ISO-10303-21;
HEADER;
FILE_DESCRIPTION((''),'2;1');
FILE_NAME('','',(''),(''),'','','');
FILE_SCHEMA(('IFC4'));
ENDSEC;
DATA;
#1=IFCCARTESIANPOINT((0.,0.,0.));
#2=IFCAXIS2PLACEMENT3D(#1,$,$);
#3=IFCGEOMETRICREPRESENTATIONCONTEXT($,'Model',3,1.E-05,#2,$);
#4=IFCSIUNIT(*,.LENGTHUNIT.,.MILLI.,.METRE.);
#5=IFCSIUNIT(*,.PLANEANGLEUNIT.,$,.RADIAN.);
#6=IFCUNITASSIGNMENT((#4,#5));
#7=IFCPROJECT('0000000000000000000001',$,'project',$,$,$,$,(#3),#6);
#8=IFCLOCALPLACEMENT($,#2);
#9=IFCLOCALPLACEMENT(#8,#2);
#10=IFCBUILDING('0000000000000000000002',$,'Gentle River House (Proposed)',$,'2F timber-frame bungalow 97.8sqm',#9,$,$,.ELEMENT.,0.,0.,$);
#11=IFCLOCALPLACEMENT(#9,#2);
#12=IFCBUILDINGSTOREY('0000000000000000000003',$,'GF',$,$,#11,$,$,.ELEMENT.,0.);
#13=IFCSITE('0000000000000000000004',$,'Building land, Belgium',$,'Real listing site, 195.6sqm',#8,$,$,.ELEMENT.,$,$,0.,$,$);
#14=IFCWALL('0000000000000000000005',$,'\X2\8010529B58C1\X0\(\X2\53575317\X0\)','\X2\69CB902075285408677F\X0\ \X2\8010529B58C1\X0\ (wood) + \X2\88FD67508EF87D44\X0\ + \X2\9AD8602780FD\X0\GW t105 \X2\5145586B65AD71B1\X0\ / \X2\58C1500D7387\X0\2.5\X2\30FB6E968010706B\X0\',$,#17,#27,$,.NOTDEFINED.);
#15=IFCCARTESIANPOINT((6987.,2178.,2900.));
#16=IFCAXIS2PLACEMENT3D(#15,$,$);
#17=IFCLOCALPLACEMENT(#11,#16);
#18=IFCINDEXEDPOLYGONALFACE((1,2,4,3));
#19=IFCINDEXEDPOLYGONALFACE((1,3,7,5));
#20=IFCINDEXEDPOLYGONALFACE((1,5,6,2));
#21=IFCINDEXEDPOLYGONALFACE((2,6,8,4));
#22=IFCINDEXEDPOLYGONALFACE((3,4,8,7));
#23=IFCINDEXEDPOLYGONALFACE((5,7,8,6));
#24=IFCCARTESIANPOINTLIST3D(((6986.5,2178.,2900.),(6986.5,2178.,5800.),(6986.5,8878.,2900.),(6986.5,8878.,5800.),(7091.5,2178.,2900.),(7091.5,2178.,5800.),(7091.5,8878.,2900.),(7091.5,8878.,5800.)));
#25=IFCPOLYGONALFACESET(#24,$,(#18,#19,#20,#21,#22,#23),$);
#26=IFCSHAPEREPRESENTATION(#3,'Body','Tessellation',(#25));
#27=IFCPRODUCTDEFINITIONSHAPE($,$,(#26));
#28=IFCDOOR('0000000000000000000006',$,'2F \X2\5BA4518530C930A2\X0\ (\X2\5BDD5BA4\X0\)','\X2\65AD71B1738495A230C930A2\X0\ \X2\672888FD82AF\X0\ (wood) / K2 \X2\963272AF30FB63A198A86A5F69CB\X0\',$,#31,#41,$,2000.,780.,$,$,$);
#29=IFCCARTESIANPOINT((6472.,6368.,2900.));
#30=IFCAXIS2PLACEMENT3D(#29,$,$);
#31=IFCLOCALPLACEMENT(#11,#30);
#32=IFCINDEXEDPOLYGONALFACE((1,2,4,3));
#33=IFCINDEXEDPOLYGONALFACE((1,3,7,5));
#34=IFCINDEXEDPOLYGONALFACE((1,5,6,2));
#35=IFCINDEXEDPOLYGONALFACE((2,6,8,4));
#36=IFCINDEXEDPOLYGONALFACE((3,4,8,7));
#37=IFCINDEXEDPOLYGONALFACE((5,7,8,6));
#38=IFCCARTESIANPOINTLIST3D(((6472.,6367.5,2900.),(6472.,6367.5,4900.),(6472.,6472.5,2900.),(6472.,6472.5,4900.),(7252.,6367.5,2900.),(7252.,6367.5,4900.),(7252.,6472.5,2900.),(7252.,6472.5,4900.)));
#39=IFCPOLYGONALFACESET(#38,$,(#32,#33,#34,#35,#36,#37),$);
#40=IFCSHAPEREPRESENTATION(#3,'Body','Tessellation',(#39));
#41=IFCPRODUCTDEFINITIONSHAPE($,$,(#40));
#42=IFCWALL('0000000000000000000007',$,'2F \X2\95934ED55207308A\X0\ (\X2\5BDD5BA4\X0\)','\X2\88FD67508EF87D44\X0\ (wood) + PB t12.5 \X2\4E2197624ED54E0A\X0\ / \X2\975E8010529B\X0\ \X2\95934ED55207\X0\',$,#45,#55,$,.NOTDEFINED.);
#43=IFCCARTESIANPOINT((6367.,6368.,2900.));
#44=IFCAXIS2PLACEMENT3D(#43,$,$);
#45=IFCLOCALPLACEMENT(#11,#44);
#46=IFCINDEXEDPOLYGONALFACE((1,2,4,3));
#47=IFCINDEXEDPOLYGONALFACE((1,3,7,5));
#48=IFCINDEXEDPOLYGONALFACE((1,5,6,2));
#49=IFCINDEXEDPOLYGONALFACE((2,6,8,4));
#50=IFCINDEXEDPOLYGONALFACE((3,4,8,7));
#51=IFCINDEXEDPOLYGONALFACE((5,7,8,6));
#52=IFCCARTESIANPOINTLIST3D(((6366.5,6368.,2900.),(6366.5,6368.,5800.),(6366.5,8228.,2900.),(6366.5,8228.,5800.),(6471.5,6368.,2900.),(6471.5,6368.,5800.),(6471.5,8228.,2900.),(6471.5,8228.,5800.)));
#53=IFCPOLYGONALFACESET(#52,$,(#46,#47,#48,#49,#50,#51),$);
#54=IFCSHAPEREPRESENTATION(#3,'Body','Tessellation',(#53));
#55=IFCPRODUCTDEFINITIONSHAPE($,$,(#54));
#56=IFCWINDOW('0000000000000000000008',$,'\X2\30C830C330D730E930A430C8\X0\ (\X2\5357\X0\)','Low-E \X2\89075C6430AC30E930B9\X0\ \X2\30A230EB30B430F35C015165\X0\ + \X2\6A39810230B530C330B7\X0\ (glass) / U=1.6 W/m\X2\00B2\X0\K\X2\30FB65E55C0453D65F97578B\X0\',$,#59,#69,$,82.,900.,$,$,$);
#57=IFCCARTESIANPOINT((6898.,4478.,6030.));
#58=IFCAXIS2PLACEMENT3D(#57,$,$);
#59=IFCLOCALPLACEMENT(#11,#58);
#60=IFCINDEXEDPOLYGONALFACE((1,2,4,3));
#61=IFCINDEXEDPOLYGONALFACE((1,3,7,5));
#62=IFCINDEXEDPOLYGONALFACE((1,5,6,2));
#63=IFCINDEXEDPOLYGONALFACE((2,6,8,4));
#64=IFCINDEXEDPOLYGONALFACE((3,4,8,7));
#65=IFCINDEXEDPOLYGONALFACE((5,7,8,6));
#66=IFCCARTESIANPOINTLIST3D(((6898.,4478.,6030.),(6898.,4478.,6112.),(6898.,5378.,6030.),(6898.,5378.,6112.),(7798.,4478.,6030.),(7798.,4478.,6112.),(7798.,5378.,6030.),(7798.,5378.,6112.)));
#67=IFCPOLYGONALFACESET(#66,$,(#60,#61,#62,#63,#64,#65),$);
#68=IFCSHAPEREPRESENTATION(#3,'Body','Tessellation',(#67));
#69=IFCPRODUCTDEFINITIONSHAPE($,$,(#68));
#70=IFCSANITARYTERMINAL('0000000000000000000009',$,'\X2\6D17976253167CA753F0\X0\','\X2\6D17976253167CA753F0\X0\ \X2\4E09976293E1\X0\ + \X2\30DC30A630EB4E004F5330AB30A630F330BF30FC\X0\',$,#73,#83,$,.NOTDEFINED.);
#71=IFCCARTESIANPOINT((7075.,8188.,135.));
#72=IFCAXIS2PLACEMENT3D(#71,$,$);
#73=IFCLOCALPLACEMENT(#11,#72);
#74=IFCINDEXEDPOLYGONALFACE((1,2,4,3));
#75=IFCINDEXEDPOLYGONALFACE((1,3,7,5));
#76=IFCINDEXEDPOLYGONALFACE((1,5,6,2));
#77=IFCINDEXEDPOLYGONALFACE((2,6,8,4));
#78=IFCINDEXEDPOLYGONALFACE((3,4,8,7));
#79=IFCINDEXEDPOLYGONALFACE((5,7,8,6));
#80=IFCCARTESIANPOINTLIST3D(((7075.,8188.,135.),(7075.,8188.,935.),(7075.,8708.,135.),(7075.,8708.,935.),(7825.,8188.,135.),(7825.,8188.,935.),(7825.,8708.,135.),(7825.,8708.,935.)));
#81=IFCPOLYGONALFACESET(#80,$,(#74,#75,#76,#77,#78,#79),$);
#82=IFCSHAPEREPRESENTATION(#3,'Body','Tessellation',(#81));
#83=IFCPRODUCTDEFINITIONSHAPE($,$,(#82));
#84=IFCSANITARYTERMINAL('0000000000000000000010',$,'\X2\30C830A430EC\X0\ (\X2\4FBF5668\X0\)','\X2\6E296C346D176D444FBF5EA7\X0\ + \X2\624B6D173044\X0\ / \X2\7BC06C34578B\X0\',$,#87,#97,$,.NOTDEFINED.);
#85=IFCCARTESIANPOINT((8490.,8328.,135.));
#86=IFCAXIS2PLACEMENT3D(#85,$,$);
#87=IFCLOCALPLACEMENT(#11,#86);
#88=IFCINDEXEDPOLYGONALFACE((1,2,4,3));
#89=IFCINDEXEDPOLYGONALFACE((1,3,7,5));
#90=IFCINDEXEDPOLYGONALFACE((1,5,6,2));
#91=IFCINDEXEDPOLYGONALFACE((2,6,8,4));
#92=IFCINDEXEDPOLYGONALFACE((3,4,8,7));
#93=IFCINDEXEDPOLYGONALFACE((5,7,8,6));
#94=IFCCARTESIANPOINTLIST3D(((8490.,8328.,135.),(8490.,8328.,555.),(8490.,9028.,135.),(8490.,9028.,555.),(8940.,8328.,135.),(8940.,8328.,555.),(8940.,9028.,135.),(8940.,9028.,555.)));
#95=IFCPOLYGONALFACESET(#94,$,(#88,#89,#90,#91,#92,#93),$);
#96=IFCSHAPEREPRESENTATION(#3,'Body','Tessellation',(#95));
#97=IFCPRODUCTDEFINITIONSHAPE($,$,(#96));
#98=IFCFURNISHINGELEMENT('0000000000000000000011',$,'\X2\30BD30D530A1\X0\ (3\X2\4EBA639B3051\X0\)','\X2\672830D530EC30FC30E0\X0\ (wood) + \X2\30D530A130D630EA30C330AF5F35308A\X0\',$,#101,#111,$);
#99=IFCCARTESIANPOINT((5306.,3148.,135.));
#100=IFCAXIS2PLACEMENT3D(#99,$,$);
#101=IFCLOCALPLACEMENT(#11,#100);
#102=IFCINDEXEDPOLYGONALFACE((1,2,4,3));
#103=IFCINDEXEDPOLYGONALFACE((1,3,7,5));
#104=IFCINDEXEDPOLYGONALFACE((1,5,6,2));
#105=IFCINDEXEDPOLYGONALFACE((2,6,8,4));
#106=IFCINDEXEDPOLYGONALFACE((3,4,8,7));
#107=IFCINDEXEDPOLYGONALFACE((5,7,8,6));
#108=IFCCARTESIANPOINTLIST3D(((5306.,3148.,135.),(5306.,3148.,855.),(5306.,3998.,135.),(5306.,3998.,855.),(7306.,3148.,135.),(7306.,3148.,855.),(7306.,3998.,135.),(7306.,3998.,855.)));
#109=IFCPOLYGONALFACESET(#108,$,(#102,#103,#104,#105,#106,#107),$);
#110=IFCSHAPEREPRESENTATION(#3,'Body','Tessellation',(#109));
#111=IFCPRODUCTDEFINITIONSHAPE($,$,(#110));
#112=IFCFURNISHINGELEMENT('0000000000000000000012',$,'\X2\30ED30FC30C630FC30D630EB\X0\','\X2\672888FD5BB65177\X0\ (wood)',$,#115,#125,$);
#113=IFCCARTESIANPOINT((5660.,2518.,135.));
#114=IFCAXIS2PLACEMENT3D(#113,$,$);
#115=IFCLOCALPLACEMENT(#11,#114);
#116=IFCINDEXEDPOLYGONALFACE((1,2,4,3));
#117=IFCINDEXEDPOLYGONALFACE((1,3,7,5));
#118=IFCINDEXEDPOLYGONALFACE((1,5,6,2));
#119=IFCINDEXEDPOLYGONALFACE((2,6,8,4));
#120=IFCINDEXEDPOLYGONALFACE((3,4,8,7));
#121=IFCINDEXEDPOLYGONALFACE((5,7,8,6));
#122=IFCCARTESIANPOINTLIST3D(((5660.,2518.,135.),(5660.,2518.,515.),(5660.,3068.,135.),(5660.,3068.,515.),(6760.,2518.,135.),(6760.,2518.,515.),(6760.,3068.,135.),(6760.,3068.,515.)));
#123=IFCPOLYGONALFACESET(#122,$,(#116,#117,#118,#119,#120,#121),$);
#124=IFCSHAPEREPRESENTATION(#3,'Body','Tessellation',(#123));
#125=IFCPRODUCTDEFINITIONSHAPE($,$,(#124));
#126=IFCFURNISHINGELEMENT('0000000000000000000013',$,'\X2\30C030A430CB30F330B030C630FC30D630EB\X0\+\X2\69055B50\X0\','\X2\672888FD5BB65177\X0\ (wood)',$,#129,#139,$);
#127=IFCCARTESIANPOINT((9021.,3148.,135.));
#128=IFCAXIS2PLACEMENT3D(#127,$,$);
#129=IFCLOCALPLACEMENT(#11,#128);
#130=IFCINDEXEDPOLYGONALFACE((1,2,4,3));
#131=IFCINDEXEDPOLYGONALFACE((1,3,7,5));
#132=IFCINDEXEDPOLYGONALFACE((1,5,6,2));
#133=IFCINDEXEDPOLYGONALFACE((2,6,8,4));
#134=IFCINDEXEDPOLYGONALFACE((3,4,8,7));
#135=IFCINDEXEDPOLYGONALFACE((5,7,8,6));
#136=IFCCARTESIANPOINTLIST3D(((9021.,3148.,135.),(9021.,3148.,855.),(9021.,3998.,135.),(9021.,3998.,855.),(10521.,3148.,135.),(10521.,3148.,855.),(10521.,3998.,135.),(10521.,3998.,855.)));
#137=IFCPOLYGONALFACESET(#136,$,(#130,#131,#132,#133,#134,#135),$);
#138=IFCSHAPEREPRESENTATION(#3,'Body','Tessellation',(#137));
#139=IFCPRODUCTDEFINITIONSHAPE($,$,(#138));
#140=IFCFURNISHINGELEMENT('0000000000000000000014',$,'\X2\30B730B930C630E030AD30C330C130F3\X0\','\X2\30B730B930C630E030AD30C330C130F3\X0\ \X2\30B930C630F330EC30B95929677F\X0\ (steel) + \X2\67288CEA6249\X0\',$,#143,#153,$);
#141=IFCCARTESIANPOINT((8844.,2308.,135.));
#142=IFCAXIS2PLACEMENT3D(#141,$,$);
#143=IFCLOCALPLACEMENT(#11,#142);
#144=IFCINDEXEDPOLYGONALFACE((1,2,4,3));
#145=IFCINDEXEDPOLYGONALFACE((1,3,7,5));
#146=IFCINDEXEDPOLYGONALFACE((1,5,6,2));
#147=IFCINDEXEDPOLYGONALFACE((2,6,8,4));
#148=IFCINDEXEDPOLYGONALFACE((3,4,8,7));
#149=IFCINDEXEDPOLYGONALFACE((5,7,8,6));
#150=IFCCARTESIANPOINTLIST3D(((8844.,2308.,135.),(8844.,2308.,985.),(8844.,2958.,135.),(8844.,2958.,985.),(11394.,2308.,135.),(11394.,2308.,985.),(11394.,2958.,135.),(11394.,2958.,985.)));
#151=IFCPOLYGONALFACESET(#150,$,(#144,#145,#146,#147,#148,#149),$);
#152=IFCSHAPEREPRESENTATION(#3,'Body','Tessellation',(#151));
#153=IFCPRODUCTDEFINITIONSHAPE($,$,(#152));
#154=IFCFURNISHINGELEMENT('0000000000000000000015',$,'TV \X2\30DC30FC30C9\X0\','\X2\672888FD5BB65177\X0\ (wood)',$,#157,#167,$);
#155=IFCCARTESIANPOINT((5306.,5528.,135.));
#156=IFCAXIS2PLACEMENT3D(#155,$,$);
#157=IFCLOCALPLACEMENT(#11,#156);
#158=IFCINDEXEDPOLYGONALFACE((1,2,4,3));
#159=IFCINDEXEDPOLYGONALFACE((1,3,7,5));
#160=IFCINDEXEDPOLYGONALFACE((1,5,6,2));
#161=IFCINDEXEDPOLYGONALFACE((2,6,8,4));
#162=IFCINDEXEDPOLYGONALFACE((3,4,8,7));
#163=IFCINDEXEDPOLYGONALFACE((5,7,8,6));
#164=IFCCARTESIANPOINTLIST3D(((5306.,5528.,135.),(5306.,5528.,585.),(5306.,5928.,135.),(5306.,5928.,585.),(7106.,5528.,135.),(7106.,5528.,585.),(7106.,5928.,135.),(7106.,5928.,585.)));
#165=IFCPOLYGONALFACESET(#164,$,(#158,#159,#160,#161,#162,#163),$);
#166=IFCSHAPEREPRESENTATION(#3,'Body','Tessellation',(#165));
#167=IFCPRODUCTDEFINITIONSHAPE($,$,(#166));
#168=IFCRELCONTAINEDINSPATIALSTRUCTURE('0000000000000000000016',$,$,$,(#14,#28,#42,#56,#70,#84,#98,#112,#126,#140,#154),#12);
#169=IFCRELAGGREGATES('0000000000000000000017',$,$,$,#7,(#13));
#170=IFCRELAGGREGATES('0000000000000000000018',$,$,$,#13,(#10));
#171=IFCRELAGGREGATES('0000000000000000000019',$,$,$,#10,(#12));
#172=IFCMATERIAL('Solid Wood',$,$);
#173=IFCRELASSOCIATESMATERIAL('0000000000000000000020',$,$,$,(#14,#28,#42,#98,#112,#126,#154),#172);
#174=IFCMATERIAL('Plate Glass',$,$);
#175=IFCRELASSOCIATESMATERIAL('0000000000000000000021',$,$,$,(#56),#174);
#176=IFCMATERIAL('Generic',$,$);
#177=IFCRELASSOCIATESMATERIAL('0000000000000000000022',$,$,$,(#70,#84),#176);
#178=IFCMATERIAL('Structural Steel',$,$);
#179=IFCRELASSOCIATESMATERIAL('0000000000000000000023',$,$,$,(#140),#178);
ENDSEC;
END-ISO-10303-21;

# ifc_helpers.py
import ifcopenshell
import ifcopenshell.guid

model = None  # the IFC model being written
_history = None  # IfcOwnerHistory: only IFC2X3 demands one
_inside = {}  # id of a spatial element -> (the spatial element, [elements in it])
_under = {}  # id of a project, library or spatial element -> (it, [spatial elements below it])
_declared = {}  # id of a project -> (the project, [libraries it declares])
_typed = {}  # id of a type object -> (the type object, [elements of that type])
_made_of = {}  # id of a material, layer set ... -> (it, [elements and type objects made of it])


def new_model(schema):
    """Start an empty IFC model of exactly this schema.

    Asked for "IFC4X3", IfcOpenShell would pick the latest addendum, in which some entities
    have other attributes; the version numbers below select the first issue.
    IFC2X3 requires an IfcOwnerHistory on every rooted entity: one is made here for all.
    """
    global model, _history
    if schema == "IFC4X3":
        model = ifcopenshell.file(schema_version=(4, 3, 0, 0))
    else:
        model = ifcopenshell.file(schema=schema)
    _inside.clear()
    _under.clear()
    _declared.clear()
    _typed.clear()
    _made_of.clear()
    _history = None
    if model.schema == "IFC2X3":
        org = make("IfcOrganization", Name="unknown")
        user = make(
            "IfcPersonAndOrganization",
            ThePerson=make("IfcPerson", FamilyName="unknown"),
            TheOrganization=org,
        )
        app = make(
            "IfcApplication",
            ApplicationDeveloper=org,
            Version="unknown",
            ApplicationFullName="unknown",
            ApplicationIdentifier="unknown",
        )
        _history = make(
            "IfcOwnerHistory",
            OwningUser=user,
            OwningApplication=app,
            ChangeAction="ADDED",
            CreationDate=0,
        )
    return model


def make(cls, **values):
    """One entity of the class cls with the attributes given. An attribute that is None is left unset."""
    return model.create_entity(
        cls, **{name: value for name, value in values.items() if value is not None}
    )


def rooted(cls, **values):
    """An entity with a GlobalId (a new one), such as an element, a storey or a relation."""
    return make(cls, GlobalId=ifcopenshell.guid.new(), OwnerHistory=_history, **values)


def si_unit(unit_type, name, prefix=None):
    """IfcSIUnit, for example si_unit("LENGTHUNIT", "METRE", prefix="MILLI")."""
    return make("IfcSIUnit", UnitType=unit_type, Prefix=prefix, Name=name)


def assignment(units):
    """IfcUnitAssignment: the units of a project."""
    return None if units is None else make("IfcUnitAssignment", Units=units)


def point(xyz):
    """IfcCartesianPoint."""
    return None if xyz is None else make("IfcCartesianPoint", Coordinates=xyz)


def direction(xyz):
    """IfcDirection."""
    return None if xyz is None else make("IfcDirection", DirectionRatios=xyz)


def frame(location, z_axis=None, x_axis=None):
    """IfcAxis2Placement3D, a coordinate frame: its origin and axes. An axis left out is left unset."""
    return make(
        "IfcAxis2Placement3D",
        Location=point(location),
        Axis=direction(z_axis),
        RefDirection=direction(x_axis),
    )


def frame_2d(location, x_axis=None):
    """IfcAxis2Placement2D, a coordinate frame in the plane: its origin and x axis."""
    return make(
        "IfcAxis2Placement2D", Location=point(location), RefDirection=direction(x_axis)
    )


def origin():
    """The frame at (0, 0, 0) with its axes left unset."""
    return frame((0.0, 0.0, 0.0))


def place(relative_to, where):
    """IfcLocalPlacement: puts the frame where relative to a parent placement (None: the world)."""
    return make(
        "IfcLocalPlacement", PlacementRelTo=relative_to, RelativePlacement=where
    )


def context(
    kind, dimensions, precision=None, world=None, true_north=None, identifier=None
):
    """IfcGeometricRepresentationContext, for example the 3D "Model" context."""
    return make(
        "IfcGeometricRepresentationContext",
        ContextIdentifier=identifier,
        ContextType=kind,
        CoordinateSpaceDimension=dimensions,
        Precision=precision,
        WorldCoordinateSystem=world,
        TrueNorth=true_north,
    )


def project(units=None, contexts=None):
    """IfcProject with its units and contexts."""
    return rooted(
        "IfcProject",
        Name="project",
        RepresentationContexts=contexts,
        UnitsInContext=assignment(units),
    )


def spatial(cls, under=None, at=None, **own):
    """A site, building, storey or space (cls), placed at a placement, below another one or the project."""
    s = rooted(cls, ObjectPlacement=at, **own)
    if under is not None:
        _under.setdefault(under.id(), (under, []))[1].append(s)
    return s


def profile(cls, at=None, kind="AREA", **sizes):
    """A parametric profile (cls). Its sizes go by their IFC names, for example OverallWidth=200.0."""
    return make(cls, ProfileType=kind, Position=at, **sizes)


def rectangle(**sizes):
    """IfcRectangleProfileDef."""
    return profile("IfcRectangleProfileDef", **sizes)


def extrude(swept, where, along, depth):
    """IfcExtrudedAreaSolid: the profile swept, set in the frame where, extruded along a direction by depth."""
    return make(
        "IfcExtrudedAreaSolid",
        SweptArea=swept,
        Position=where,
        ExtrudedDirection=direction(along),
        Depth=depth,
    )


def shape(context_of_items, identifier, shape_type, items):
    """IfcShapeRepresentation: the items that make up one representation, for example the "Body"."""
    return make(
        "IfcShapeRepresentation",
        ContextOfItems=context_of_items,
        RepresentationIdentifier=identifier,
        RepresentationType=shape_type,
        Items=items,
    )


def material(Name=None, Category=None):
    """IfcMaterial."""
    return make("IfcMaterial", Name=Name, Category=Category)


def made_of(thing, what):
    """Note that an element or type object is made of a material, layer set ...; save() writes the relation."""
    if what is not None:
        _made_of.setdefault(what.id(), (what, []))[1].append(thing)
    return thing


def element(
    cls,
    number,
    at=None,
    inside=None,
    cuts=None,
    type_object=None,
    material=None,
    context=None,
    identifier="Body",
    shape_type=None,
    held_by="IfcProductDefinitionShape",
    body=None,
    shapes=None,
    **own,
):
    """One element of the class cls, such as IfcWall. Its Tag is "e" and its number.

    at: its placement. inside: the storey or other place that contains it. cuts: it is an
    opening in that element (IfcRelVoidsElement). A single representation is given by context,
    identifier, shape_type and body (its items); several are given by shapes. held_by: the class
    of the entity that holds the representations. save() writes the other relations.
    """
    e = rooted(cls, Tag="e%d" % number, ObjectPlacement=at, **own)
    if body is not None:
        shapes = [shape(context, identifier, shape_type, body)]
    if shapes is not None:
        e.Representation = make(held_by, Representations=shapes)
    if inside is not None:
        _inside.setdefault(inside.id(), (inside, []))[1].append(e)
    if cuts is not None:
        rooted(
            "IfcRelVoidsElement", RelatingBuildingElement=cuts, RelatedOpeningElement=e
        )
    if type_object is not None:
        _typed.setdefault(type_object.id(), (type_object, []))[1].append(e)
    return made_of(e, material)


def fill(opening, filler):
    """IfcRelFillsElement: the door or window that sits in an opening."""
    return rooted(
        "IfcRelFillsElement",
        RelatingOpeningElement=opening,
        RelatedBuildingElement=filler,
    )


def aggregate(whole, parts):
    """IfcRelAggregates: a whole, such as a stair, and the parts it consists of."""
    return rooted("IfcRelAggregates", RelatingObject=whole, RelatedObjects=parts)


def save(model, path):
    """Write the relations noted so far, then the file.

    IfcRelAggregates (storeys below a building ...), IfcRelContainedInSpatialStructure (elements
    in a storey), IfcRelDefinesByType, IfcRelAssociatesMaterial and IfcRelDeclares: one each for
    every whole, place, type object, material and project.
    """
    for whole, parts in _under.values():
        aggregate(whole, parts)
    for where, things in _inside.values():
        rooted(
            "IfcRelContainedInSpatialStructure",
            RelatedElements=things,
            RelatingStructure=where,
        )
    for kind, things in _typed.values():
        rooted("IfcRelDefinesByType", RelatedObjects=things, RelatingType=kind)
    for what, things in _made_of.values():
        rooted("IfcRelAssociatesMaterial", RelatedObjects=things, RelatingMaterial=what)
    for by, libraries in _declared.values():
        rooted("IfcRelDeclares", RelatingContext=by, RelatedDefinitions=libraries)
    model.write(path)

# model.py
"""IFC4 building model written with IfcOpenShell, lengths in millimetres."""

from ifc_helpers import new_model, si_unit, frame, frame_2d, origin, place, context, project, spatial, rectangle, extrude, material, element, fill, save


model = new_model("IFC4")

# Units and contexts
model_context = context("Model", 3, precision=1e-05, world=origin())
ifc_project = project(units=[si_unit("LENGTHUNIT", "METRE", prefix="MILLI"), si_unit("PLANEANGLEUNIT", "RADIAN")], contexts=[model_context])

# Site, building, storey
site_placement = place(None, origin())
site = spatial("IfcSite", under=ifc_project, at=site_placement, Name="Building land, Belgium", ObjectType="Real listing site, 195.6sqm", CompositionType="ELEMENT", RefElevation=0.0)
building_placement = place(site_placement, origin())
building = spatial("IfcBuilding", under=site, at=building_placement, Name="Gentle River House (Proposed)", ObjectType="2F timber-frame bungalow 97.8sqm", CompositionType="ELEMENT", ElevationOfRefHeight=0.0, ElevationOfTerrain=0.0)
storey_placement = place(building_placement, origin())
storey = spatial("IfcBuildingStorey", under=building, at=storey_placement, Name="GF", CompositionType="ELEMENT", Elevation=0.0)

# Shared definitions
ifc_material_1 = material(Name="Solid Wood")

# Wall, opening, door
wall_1_placement = place(storey_placement, frame((6987.0, 2178.0, 2900.0)))
wall_1 = element("IfcWall", 1, at=wall_1_placement, inside=storey, material=ifc_material_1, Name="耐力壁(南北)", Description="構造用合板 耐力壁 (wood) + 製材軸組 + 高性能GW t105 充填断熱 / 壁倍率2.5・準耐火", PredefinedType="NOTDEFINED", context=model_context, shape_type="SweptSolid", body=[
    extrude(rectangle(XDim=105.0, YDim=6700.0, at=frame_2d((52.0, 3350.0))), frame((6987.0, 2178.0, 2900.0)), (0.0, 0.0, 1.0), 2900.0),
])
opening_1_placement = place(storey_placement, frame((6472.0, 6368.0, 2900.0)))
opening_1 = element("IfcOpeningElement", 2, at=opening_1_placement, cuts=wall_1, PredefinedType="NOTDEFINED", context=model_context, shape_type="SweptSolid", body=[
    extrude(rectangle(XDim=780.0, YDim=105.0, at=frame_2d((390.0, 52.0))), frame((6472.0, 6368.0, 2900.0)), (0.0, 0.0, 1.0), 2000.0),
])
door_1_placement = place(storey_placement, frame((6472.0, 6368.0, 2900.0)))
door_1 = element("IfcDoor", 3, at=door_1_placement, inside=storey, material=ifc_material_1, Name="2F 室内ドア (寝室)", Description="断熱玄関ドア 木製芯 (wood) / K2 防犯・採風機構", OverallHeight=2000.0, OverallWidth=780.0, context=model_context, shape_type="SweptSolid", body=[
    extrude(rectangle(XDim=780.0, YDim=105.0, at=frame_2d((390.0, 52.0))), frame((6472.0, 6368.0, 2900.0)), (0.0, 0.0, 1.0), 2000.0),
])
fill(opening_1, door_1)

# Wall
wall_2_placement = place(storey_placement, frame((6367.0, 6368.0, 2900.0)))
element("IfcWall", 4, at=wall_2_placement, inside=storey, material=ifc_material_1, Name="2F 間仕切り (寝室)", Description="製材軸組 (wood) + PB t12.5 両面仕上 / 非耐力 間仕切", PredefinedType="NOTDEFINED", context=model_context, shape_type="SweptSolid", body=[
    extrude(rectangle(XDim=105.0, YDim=1860.0, at=frame_2d((52.0, 930.0))), frame((6367.0, 6368.0, 2900.0)), (0.0, 0.0, 1.0), 2900.0),
])

# Window
ifc_material_2 = material(Name="Plate Glass")
window_placement = place(storey_placement, frame((6898.0, 4478.0, 6030.0)))
element("IfcWindow", 5, at=window_placement, inside=storey, material=ifc_material_2, Name="トップライト (南)", Description="Low-E 複層ガラス アルゴン封入 + 樹脂サッシ (glass) / U=1.6 W/m²K・日射取得型", OverallHeight=82.0, OverallWidth=900.0, context=model_context, shape_type="SweptSolid", body=[
    extrude(rectangle(XDim=900.0, YDim=900.0, at=frame_2d((450.0, 450.0))), frame((6898.0, 4478.0, 6030.0)), (0.0, 0.0, 1.0), 82.0),
])

# Sanitary terminals
ifc_material_3 = material(Name="Generic")
sanitary_terminal_1_placement = place(storey_placement, frame((7075.0, 8188.0, 135.0)))
element("IfcSanitaryTerminal", 6, at=sanitary_terminal_1_placement, inside=storey, material=ifc_material_3, Name="洗面化粧台", Description="洗面化粧台 三面鏡 + ボウル一体カウンター", PredefinedType="NOTDEFINED", context=model_context, shape_type="SweptSolid", body=[
    extrude(rectangle(XDim=750.0, YDim=520.0, at=frame_2d((375.0, 260.0))), frame((7075.0, 8188.0, 135.0)), (0.0, 0.0, 1.0), 800.0),
])
sanitary_terminal_2_placement = place(storey_placement, frame((8490.0, 8328.0, 135.0)))
element("IfcSanitaryTerminal", 7, at=sanitary_terminal_2_placement, inside=storey, material=ifc_material_3, Name="トイレ (便器)", Description="温水洗浄便座 + 手洗い / 節水型", PredefinedType="NOTDEFINED", context=model_context, shape_type="SweptSolid", body=[
    extrude(rectangle(XDim=450.0, YDim=700.0, at=frame_2d((225.0, 350.0))), frame((8490.0, 8328.0, 135.0)), (0.0, 0.0, 1.0), 420.0),
])

# Furnishing elements
furnishing_1_placement = place(storey_placement, frame((5306.0, 3148.0, 135.0)))
element("IfcFurnishingElement", 8, at=furnishing_1_placement, inside=storey, material=ifc_material_1, Name="ソファ (3人掛け)", Description="木フレーム (wood) + ファブリック張り", context=model_context, shape_type="SweptSolid", body=[
    extrude(rectangle(XDim=2000.0, YDim=850.0, at=frame_2d((1000.0, 425.0))), frame((5306.0, 3148.0, 135.0)), (0.0, 0.0, 1.0), 720.0),
])
furnishing_2_placement = place(storey_placement, frame((5660.0, 2518.0, 135.0)))
element("IfcFurnishingElement", 9, at=furnishing_2_placement, inside=storey, material=ifc_material_1, Name="ローテーブル", Description="木製家具 (wood)", context=model_context, shape_type="SweptSolid", body=[
    extrude(rectangle(XDim=1100.0, YDim=550.0, at=frame_2d((550.0, 275.0))), frame((5660.0, 2518.0, 135.0)), (0.0, 0.0, 1.0), 380.0),
])
furnishing_3_placement = place(storey_placement, frame((9021.0, 3148.0, 135.0)))
element("IfcFurnishingElement", 10, at=furnishing_3_placement, inside=storey, material=ifc_material_1, Name="ダイニングテーブル+椅子", Description="木製家具 (wood)", context=model_context, shape_type="SweptSolid", body=[
    extrude(rectangle(XDim=1500.0, YDim=850.0, at=frame_2d((750.0, 425.0))), frame((9021.0, 3148.0, 135.0)), (0.0, 0.0, 1.0), 720.0),
])
ifc_material_4 = material(Name="Structural Steel")
furnishing_4_placement = place(storey_placement, frame((8844.0, 2308.0, 135.0)))
element("IfcFurnishingElement", 11, at=furnishing_4_placement, inside=storey, material=ifc_material_4, Name="システムキッチン", Description="システムキッチン ステンレス天板 (steel) + 木質扉", context=model_context, shape_type="SweptSolid", body=[
    extrude(rectangle(XDim=2550.0, YDim=650.0, at=frame_2d((1275.0, 325.0))), frame((8844.0, 2308.0, 135.0)), (0.0, 0.0, 1.0), 850.0),
])
furnishing_5_placement = place(storey_placement, frame((5306.0, 5528.0, 135.0)))
element("IfcFurnishingElement", 12, at=furnishing_5_placement, inside=storey, material=ifc_material_1, Name="TV ボード", Description="木製家具 (wood)", context=model_context, shape_type="SweptSolid", body=[
    extrude(rectangle(XDim=1800.0, YDim=400.0, at=frame_2d((900.0, 200.0))), frame((5306.0, 5528.0, 135.0)), (0.0, 0.0, 1.0), 450.0),
])

save(model, "model.ifc")
